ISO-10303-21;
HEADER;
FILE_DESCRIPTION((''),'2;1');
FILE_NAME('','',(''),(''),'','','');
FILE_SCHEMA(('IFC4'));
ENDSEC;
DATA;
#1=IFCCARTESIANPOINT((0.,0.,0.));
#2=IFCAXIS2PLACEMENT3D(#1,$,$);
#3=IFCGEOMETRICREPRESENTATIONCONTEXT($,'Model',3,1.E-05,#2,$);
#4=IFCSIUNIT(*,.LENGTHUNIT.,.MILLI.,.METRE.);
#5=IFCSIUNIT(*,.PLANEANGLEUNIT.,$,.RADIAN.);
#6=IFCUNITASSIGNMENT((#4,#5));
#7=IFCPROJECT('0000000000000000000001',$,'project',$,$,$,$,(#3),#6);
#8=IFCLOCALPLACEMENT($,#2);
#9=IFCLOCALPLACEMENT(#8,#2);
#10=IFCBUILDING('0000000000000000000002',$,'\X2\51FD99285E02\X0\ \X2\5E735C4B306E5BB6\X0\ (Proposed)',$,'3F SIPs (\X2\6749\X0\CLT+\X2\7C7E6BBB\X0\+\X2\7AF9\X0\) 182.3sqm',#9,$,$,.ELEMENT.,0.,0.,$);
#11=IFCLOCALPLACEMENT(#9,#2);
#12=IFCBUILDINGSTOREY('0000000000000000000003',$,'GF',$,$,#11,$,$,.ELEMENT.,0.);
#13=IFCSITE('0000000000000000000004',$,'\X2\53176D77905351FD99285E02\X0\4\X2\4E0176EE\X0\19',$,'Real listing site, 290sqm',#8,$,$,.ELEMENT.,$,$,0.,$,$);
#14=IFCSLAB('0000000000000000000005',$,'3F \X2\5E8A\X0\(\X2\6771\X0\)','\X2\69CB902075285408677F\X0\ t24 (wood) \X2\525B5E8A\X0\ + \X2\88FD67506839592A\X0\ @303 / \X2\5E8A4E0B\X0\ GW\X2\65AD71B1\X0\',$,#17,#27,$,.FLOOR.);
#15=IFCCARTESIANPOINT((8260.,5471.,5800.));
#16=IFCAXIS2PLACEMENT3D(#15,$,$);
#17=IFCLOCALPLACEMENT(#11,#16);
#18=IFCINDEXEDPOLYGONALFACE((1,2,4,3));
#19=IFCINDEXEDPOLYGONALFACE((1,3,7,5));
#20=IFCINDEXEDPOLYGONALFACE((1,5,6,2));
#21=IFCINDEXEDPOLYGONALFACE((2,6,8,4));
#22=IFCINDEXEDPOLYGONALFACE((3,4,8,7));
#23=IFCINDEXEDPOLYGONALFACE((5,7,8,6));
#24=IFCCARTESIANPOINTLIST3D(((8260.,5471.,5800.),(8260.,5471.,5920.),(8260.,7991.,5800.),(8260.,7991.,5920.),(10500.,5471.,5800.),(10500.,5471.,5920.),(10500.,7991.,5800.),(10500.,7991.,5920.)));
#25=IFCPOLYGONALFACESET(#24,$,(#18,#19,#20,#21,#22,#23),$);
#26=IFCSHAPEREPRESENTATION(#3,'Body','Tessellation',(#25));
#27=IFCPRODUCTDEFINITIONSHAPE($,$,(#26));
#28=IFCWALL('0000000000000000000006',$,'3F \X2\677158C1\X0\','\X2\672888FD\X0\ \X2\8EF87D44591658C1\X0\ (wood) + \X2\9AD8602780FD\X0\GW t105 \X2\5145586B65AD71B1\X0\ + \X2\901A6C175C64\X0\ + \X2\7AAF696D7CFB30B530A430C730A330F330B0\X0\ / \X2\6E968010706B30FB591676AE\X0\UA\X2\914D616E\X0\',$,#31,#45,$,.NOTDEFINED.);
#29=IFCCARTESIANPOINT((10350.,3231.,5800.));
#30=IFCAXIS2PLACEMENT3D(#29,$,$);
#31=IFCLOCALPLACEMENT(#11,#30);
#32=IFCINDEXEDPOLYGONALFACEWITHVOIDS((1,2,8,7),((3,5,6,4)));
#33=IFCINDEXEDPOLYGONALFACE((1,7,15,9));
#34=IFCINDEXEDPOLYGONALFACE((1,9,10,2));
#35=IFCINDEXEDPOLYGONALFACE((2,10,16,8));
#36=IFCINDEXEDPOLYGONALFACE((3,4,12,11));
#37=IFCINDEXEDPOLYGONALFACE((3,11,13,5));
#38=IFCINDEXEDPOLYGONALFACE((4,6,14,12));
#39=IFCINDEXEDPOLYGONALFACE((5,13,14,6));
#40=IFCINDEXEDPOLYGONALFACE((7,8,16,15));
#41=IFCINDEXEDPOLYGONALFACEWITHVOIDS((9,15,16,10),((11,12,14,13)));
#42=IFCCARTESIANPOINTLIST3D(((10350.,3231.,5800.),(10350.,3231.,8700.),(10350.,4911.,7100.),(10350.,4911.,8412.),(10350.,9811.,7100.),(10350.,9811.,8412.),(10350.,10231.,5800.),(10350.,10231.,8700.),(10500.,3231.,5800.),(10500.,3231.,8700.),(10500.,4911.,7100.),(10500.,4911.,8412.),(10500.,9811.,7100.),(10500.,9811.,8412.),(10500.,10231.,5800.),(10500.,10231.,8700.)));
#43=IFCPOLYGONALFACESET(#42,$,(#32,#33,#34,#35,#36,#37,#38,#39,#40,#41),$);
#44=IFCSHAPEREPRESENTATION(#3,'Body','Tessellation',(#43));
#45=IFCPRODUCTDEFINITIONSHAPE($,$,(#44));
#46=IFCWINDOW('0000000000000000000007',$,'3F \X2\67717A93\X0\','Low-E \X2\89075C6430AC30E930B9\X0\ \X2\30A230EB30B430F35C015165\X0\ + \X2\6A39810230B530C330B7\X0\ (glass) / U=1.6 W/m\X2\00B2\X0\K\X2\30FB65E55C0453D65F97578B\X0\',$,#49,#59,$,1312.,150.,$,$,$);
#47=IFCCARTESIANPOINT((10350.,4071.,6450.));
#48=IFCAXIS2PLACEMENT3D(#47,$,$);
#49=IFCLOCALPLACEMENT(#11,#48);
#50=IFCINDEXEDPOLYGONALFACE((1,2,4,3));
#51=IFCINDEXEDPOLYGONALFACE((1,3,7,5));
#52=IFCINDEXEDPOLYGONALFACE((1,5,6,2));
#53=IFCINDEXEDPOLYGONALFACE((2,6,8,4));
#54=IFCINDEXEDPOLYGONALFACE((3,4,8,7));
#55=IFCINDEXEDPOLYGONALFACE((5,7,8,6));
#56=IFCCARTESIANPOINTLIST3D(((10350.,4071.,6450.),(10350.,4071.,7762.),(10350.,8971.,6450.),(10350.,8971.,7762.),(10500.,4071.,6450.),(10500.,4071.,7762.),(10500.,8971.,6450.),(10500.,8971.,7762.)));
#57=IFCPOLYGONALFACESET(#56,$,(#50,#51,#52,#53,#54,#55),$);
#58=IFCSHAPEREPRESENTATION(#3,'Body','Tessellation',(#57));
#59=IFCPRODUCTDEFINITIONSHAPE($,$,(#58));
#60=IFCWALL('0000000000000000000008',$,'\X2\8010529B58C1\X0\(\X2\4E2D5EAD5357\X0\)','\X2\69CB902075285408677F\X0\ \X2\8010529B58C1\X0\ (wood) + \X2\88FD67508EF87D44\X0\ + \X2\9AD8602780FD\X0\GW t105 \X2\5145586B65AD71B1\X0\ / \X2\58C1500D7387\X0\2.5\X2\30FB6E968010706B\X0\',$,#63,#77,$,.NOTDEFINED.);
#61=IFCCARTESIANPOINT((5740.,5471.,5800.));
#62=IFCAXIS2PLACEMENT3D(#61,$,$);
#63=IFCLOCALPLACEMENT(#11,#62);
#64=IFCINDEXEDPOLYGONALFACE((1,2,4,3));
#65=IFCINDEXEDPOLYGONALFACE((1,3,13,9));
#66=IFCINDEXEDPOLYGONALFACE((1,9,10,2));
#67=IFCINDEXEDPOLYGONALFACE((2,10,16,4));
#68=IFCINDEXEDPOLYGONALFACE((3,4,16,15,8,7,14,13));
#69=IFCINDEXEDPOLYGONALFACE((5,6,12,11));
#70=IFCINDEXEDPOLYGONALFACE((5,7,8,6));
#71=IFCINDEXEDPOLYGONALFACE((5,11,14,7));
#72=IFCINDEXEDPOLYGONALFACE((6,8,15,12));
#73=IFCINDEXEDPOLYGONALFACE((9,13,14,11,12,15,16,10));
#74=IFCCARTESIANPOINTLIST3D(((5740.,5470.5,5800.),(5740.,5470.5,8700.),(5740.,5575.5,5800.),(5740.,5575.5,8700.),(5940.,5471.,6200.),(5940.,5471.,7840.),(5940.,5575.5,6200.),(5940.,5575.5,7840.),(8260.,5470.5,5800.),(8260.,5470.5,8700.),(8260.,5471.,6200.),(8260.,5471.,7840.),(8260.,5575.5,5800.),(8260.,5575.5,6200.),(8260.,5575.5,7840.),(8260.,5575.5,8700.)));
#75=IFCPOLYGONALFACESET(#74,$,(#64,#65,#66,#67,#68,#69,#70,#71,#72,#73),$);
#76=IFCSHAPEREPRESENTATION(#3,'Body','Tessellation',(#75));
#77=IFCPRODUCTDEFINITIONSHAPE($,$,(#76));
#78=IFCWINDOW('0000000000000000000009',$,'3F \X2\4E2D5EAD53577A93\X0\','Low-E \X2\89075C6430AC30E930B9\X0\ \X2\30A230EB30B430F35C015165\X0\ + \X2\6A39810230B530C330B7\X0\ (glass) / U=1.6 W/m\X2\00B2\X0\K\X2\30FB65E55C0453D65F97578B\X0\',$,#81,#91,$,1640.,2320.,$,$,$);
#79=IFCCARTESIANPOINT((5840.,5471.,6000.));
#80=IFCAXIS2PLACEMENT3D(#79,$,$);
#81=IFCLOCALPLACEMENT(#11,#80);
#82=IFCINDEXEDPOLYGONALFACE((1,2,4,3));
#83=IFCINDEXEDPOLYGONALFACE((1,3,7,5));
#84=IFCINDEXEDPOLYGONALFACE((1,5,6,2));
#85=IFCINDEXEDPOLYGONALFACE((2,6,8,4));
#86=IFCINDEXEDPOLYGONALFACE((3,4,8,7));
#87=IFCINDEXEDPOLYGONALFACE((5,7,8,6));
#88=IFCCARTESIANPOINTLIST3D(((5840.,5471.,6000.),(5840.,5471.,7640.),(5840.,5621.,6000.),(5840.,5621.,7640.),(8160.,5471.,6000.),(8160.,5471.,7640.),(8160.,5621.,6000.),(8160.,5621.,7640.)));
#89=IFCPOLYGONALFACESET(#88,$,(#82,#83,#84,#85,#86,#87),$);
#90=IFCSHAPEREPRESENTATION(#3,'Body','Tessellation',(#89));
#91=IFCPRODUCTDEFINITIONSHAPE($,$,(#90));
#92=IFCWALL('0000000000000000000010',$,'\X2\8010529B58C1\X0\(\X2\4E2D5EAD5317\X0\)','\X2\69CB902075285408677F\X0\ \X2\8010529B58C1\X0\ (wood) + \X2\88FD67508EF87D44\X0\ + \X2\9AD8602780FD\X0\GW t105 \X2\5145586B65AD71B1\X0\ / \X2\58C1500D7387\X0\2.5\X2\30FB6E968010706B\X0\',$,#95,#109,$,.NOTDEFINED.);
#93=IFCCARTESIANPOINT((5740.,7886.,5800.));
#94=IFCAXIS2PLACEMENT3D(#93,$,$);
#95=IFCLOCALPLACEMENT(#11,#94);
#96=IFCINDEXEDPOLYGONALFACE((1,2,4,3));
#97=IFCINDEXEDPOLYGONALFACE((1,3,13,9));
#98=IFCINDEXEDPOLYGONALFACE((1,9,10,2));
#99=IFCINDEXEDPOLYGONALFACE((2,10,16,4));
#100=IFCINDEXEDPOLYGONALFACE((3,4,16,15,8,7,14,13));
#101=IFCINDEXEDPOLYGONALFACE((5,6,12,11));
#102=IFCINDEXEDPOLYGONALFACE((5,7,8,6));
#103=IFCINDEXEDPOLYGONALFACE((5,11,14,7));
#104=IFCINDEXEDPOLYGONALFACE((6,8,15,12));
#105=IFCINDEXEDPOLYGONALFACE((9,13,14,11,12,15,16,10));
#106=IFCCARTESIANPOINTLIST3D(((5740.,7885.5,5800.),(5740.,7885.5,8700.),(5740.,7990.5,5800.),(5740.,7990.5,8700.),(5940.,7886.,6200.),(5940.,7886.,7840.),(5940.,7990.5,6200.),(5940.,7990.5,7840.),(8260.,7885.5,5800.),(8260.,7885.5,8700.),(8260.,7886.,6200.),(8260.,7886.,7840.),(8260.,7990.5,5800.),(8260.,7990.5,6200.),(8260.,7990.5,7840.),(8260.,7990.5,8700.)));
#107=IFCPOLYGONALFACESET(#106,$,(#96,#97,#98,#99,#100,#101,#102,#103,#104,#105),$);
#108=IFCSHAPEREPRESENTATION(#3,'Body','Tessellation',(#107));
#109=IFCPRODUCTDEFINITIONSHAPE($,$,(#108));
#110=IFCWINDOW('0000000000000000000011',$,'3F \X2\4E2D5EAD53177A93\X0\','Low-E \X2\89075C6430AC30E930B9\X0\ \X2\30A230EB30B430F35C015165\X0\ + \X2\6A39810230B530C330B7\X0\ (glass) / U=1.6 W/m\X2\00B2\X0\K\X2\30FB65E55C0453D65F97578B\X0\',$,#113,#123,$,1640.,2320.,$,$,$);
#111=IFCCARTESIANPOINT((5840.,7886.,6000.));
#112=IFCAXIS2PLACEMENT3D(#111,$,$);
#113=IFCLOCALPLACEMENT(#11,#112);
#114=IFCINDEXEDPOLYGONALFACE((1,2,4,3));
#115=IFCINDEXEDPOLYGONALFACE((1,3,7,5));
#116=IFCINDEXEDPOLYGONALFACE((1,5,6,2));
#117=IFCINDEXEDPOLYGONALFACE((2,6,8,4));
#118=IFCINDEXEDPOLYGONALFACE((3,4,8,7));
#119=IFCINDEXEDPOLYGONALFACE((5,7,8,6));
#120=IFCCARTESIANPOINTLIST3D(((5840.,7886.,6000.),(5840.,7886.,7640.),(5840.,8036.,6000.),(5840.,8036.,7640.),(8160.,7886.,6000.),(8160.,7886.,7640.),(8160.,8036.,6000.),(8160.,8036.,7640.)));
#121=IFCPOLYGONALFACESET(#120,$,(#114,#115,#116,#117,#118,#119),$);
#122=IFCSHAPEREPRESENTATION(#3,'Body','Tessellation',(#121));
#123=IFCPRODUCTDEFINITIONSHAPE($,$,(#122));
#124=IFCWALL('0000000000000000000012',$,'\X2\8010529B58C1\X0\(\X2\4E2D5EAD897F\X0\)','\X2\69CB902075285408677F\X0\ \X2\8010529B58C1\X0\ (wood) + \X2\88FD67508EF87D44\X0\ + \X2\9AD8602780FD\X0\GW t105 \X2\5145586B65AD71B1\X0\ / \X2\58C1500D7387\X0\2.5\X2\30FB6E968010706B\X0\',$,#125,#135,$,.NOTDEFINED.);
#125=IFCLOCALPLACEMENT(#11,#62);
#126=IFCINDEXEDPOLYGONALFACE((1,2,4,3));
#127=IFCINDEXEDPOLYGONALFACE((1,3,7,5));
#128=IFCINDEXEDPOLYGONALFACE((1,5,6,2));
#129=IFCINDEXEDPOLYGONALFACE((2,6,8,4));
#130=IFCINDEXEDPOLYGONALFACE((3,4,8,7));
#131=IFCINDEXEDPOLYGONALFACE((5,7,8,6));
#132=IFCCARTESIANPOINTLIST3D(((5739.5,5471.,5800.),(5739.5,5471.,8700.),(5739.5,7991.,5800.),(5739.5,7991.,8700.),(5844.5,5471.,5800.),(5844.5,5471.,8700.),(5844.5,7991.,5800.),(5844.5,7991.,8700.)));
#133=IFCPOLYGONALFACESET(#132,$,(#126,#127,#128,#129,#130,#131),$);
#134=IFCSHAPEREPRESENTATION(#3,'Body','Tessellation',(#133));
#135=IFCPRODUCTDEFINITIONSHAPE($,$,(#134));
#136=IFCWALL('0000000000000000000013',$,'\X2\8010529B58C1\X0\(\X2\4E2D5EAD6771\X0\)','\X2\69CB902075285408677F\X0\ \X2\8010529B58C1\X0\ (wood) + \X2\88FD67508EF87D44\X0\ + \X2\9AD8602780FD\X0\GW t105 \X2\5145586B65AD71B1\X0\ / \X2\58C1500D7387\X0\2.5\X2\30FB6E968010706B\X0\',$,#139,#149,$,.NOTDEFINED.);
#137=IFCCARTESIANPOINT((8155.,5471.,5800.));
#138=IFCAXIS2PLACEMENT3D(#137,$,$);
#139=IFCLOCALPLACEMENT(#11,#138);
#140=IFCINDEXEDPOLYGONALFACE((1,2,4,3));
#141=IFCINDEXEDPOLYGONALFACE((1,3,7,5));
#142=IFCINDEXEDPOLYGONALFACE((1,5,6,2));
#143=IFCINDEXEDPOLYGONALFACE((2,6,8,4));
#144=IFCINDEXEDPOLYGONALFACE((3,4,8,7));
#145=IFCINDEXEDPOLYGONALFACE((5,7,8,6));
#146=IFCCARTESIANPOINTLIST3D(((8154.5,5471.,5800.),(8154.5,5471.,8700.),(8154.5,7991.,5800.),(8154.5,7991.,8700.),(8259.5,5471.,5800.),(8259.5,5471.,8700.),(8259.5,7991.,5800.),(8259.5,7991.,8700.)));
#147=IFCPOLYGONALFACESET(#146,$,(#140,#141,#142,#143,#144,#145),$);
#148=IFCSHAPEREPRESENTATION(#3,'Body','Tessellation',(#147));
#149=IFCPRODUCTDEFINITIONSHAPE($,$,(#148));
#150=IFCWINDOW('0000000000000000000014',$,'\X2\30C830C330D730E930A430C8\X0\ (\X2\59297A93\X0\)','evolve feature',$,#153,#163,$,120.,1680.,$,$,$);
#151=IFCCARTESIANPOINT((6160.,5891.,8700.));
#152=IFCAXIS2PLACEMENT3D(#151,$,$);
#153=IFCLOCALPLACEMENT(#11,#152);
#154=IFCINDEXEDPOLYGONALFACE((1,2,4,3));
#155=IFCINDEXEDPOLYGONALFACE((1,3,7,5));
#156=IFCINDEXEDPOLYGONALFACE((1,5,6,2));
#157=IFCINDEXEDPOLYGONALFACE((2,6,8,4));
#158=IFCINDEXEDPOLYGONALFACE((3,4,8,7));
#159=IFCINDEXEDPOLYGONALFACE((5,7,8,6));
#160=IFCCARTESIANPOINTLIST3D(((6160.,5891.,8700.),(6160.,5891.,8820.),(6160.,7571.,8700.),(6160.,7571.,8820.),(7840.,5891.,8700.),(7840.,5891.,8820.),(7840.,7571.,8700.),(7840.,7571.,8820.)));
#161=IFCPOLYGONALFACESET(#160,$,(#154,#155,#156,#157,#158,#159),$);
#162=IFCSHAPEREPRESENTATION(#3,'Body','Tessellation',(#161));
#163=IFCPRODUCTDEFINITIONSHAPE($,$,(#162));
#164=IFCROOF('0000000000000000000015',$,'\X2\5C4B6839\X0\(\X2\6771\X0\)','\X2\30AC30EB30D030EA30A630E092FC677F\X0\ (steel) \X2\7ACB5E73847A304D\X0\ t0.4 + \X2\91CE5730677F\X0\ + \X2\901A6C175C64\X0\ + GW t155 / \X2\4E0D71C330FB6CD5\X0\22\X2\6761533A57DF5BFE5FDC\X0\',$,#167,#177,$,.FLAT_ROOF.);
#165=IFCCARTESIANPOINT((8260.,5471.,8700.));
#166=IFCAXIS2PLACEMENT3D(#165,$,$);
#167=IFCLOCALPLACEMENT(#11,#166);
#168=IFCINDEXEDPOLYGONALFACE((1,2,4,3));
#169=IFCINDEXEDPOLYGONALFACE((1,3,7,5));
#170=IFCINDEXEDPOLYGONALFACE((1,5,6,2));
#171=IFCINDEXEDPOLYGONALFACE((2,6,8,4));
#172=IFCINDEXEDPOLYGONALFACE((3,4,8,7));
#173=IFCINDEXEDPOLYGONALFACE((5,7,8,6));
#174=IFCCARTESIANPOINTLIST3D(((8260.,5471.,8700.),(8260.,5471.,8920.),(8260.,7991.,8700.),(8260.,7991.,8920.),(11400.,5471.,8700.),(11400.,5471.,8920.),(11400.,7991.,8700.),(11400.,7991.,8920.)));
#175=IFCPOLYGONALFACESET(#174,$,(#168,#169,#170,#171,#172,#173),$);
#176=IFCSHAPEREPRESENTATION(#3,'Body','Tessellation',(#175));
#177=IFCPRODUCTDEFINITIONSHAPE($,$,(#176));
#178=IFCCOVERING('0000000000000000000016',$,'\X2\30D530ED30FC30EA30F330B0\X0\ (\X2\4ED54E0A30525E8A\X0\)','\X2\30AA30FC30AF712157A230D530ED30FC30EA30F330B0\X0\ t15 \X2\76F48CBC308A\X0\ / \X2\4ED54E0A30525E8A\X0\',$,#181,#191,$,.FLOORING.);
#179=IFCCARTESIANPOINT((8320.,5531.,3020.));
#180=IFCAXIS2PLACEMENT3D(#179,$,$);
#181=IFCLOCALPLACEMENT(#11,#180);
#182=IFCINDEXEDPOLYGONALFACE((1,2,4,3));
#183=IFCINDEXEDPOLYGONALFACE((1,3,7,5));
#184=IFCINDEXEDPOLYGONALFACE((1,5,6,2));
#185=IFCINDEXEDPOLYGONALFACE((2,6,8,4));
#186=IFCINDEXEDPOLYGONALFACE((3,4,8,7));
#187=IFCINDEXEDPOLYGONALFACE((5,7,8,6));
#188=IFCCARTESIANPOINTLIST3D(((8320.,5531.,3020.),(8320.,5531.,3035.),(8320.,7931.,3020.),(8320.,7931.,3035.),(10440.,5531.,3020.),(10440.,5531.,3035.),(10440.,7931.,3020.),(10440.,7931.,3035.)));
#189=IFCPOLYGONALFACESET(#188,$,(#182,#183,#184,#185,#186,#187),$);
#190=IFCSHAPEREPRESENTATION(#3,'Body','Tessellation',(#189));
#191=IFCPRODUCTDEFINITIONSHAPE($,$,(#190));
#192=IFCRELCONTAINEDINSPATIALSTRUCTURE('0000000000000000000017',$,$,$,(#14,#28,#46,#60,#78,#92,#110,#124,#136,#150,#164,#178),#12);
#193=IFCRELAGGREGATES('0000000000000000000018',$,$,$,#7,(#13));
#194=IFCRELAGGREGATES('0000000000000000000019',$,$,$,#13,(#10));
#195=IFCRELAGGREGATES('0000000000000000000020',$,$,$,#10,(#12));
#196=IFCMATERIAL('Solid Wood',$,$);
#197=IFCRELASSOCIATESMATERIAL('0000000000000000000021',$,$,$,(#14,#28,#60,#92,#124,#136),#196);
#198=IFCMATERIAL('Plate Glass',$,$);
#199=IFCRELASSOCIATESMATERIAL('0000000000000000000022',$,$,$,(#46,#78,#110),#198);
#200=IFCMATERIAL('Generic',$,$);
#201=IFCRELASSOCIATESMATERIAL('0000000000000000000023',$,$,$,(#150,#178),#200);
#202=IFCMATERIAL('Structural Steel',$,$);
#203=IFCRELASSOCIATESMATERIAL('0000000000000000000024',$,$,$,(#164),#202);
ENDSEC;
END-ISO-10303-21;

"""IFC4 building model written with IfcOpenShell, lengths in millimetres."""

from ifc_helpers import new_model, si_unit, frame, frame_2d, origin, place, context, project, spatial, rectangle, extrude, material, element, fill, save


model = new_model("IFC4")

# Units and contexts
model_context = context("Model", 3, precision=1e-05, world=origin())
ifc_project = project(units=[si_unit("LENGTHUNIT", "METRE", prefix="MILLI"), si_unit("PLANEANGLEUNIT", "RADIAN")], contexts=[model_context])

# Site, building, storey
site_placement = place(None, origin())
site = spatial("IfcSite", under=ifc_project, at=site_placement, Name="北海道函館市4丁目19", ObjectType="Real listing site, 290sqm", CompositionType="ELEMENT", RefElevation=0.0)
building_placement = place(site_placement, origin())
building = spatial("IfcBuilding", under=site, at=building_placement, Name="函館市 平屋の家 (Proposed)", ObjectType="3F SIPs (杉CLT+籾殻+竹) 182.3sqm", CompositionType="ELEMENT", ElevationOfRefHeight=0.0, ElevationOfTerrain=0.0)
storey_placement = place(building_placement, origin())
storey = spatial("IfcBuildingStorey", under=building, at=storey_placement, Name="GF", CompositionType="ELEMENT", Elevation=0.0)

# Slab
ifc_material_1 = material(Name="Solid Wood")
slab_placement = place(storey_placement, frame((8260.0, 5471.0, 5800.0)))
element("IfcSlab", 1, at=slab_placement, inside=storey, material=ifc_material_1, Name="3F 床(東)", Description="構造用合板 t24 (wood) 剛床 + 製材根太 @303 / 床下 GW断熱", PredefinedType="FLOOR", context=model_context, shape_type="SweptSolid", body=[
    extrude(rectangle(XDim=2240.0, YDim=2520.0, at=frame_2d((1120.0, 1260.0))), frame((8260.0, 5471.0, 5800.0)), (0.0, 0.0, 1.0), 120.0),
])

# Walls, openings, windows
wall_1_placement = place(storey_placement, frame((10350.0, 3231.0, 5800.0)))
wall_1 = element("IfcWall", 2, at=wall_1_placement, inside=storey, material=ifc_material_1, Name="3F 東壁", Description="木製 軸組外壁 (wood) + 高性能GW t105 充填断熱 + 通気層 + 窯業系サイディング / 準耐火・外皮UA配慮", PredefinedType="NOTDEFINED", context=model_context, shape_type="SweptSolid", body=[
    extrude(rectangle(XDim=150.0, YDim=7000.0, at=frame_2d((75.0, 3500.0))), frame((10350.0, 3231.0, 5800.0)), (0.0, 0.0, 1.0), 2900.0),
])
opening_1_placement = place(storey_placement, frame((10350.0, 4071.0, 6450.0)))
opening_1 = element("IfcOpeningElement", 3, at=opening_1_placement, cuts=wall_1, PredefinedType="NOTDEFINED", context=model_context, shape_type="SweptSolid", body=[
    extrude(rectangle(XDim=150.0, YDim=4900.0, at=frame_2d((75.0, 2450.0))), frame((10350.0, 4071.0, 6450.0)), (0.0, 0.0, 1.0), 1312.0),
])
ifc_material_2 = material(Name="Plate Glass")
window_1_placement = place(storey_placement, frame((10350.0, 4071.0, 6450.0)))
window_1 = element("IfcWindow", 4, at=window_1_placement, inside=storey, material=ifc_material_2, Name="3F 東窓", Description="Low-E 複層ガラス アルゴン封入 + 樹脂サッシ (glass) / U=1.6 W/m²K・日射取得型", OverallHeight=1312.0, OverallWidth=150.0, context=model_context, shape_type="SweptSolid", body=[
    extrude(rectangle(XDim=150.0, YDim=4900.0, at=frame_2d((75.0, 2450.0))), frame((10350.0, 4071.0, 6450.0)), (0.0, 0.0, 1.0), 1312.0),
])
fill(opening_1, window_1)
wall_2_placement = place(storey_placement, frame((5740.0, 5471.0, 5800.0)))
wall_2 = element("IfcWall", 5, at=wall_2_placement, inside=storey, material=ifc_material_1, Name="耐力壁(中庭南)", Description="構造用合板 耐力壁 (wood) + 製材軸組 + 高性能GW t105 充填断熱 / 壁倍率2.5・準耐火", PredefinedType="NOTDEFINED", context=model_context, shape_type="SweptSolid", body=[
    extrude(rectangle(XDim=2520.0, YDim=105.0, at=frame_2d((1260.0, 52.0))), frame((5740.0, 5471.0, 5800.0)), (0.0, 0.0, 1.0), 2900.0),
])
opening_2_placement = place(storey_placement, frame((5840.0, 5471.0, 6000.0)))
opening_2 = element("IfcOpeningElement", 6, at=opening_2_placement, cuts=wall_2, PredefinedType="NOTDEFINED", context=model_context, shape_type="SweptSolid", body=[
    extrude(rectangle(XDim=2320.0, YDim=150.0, at=frame_2d((1160.0, 75.0))), frame((5840.0, 5471.0, 6000.0)), (0.0, 0.0, 1.0), 1640.0),
])
window_2_placement = place(storey_placement, frame((5840.0, 5471.0, 6000.0)))
window_2 = element("IfcWindow", 7, at=window_2_placement, inside=storey, material=ifc_material_2, Name="3F 中庭南窓", Description="Low-E 複層ガラス アルゴン封入 + 樹脂サッシ (glass) / U=1.6 W/m²K・日射取得型", OverallHeight=1640.0, OverallWidth=2320.0, context=model_context, shape_type="SweptSolid", body=[
    extrude(rectangle(XDim=2320.0, YDim=150.0, at=frame_2d((1160.0, 75.0))), frame((5840.0, 5471.0, 6000.0)), (0.0, 0.0, 1.0), 1640.0),
])
fill(opening_2, window_2)
wall_3_placement = place(storey_placement, frame((5740.0, 7886.0, 5800.0)))
wall_3 = element("IfcWall", 8, at=wall_3_placement, inside=storey, material=ifc_material_1, Name="耐力壁(中庭北)", Description="構造用合板 耐力壁 (wood) + 製材軸組 + 高性能GW t105 充填断熱 / 壁倍率2.5・準耐火", PredefinedType="NOTDEFINED", context=model_context, shape_type="SweptSolid", body=[
    extrude(rectangle(XDim=2520.0, YDim=105.0, at=frame_2d((1260.0, 52.0))), frame((5740.0, 7886.0, 5800.0)), (0.0, 0.0, 1.0), 2900.0),
])
opening_3_placement = place(storey_placement, frame((5840.0, 7886.0, 6000.0)))
opening_3 = element("IfcOpeningElement", 9, at=opening_3_placement, cuts=wall_3, PredefinedType="NOTDEFINED", context=model_context, shape_type="SweptSolid", body=[
    extrude(rectangle(XDim=2320.0, YDim=150.0, at=frame_2d((1160.0, 75.0))), frame((5840.0, 7886.0, 6000.0)), (0.0, 0.0, 1.0), 1640.0),
])
window_3_placement = place(storey_placement, frame((5840.0, 7886.0, 6000.0)))
window_3 = element("IfcWindow", 10, at=window_3_placement, inside=storey, material=ifc_material_2, Name="3F 中庭北窓", Description="Low-E 複層ガラス アルゴン封入 + 樹脂サッシ (glass) / U=1.6 W/m²K・日射取得型", OverallHeight=1640.0, OverallWidth=2320.0, context=model_context, shape_type="SweptSolid", body=[
    extrude(rectangle(XDim=2320.0, YDim=150.0, at=frame_2d((1160.0, 75.0))), frame((5840.0, 7886.0, 6000.0)), (0.0, 0.0, 1.0), 1640.0),
])
fill(opening_3, window_3)

# Walls
wall_4_placement = place(storey_placement, frame((5740.0, 5471.0, 5800.0)))
element("IfcWall", 11, at=wall_4_placement, inside=storey, material=ifc_material_1, Name="耐力壁(中庭西)", Description="構造用合板 耐力壁 (wood) + 製材軸組 + 高性能GW t105 充填断熱 / 壁倍率2.5・準耐火", PredefinedType="NOTDEFINED", context=model_context, shape_type="SweptSolid", body=[
    extrude(rectangle(XDim=105.0, YDim=2520.0, at=frame_2d((52.0, 1260.0))), frame((5740.0, 5471.0, 5800.0)), (0.0, 0.0, 1.0), 2900.0),
])
wall_5_placement = place(storey_placement, frame((8155.0, 5471.0, 5800.0)))
element("IfcWall", 12, at=wall_5_placement, inside=storey, material=ifc_material_1, Name="耐力壁(中庭東)", Description="構造用合板 耐力壁 (wood) + 製材軸組 + 高性能GW t105 充填断熱 / 壁倍率2.5・準耐火", PredefinedType="NOTDEFINED", context=model_context, shape_type="SweptSolid", body=[
    extrude(rectangle(XDim=105.0, YDim=2520.0, at=frame_2d((52.0, 1260.0))), frame((8155.0, 5471.0, 5800.0)), (0.0, 0.0, 1.0), 2900.0),
])

# Window
ifc_material_3 = material(Name="Generic")
window_4_placement = place(storey_placement, frame((6160.0, 5891.0, 8700.0)))
element("IfcWindow", 13, at=window_4_placement, inside=storey, material=ifc_material_3, Name="トップライト (天窓)", Description="evolve feature", OverallHeight=120.0, OverallWidth=1680.0, context=model_context, shape_type="SweptSolid", body=[
    extrude(rectangle(XDim=1680.0, YDim=1680.0, at=frame_2d((840.0, 840.0))), frame((6160.0, 5891.0, 8700.0)), (0.0, 0.0, 1.0), 120.0),
])

# Roof
ifc_material_4 = material(Name="Structural Steel")
for number, where, name in (
    (14, (8260.0, 5471.0, 8700.0), "屋根(東)"),
):
    element("IfcRoof", number, at=place(storey_placement, frame(where)), inside=storey, material=ifc_material_4, Name=name, Description="ガルバリウム鋼板 (steel) 立平葺き t0.4 + 野地板 + 通気層 + GW t155 / 不燃・法22条区域対応", PredefinedType="FLAT_ROOF", context=model_context, shape_type="SweptSolid", body=[
        extrude(rectangle(XDim=3140.0, YDim=2520.0, at=frame_2d((1570.0, 1260.0))), frame((8260.0, 5471.0, 8700.0)), (0.0, 0.0, 1.0), 220.0),
    ])

# Covering
covering_1_placement = place(storey_placement, frame((8320.0, 5531.0, 3020.0)))
element("IfcCovering", 15, at=covering_1_placement, inside=storey, material=ifc_material_3, Name="フローリング (仕上げ床)", Description="オーク無垢フローリング t15 直貼り / 仕上げ床", PredefinedType="FLOORING", context=model_context, shape_type="SweptSolid", body=[
    extrude(rectangle(XDim=2120.0, YDim=2400.0, at=frame_2d((1060.0, 1200.0))), frame((8320.0, 5531.0, 3020.0)), (0.0, 0.0, 1.0), 15.0),
])

save(model, "model.ifc")
